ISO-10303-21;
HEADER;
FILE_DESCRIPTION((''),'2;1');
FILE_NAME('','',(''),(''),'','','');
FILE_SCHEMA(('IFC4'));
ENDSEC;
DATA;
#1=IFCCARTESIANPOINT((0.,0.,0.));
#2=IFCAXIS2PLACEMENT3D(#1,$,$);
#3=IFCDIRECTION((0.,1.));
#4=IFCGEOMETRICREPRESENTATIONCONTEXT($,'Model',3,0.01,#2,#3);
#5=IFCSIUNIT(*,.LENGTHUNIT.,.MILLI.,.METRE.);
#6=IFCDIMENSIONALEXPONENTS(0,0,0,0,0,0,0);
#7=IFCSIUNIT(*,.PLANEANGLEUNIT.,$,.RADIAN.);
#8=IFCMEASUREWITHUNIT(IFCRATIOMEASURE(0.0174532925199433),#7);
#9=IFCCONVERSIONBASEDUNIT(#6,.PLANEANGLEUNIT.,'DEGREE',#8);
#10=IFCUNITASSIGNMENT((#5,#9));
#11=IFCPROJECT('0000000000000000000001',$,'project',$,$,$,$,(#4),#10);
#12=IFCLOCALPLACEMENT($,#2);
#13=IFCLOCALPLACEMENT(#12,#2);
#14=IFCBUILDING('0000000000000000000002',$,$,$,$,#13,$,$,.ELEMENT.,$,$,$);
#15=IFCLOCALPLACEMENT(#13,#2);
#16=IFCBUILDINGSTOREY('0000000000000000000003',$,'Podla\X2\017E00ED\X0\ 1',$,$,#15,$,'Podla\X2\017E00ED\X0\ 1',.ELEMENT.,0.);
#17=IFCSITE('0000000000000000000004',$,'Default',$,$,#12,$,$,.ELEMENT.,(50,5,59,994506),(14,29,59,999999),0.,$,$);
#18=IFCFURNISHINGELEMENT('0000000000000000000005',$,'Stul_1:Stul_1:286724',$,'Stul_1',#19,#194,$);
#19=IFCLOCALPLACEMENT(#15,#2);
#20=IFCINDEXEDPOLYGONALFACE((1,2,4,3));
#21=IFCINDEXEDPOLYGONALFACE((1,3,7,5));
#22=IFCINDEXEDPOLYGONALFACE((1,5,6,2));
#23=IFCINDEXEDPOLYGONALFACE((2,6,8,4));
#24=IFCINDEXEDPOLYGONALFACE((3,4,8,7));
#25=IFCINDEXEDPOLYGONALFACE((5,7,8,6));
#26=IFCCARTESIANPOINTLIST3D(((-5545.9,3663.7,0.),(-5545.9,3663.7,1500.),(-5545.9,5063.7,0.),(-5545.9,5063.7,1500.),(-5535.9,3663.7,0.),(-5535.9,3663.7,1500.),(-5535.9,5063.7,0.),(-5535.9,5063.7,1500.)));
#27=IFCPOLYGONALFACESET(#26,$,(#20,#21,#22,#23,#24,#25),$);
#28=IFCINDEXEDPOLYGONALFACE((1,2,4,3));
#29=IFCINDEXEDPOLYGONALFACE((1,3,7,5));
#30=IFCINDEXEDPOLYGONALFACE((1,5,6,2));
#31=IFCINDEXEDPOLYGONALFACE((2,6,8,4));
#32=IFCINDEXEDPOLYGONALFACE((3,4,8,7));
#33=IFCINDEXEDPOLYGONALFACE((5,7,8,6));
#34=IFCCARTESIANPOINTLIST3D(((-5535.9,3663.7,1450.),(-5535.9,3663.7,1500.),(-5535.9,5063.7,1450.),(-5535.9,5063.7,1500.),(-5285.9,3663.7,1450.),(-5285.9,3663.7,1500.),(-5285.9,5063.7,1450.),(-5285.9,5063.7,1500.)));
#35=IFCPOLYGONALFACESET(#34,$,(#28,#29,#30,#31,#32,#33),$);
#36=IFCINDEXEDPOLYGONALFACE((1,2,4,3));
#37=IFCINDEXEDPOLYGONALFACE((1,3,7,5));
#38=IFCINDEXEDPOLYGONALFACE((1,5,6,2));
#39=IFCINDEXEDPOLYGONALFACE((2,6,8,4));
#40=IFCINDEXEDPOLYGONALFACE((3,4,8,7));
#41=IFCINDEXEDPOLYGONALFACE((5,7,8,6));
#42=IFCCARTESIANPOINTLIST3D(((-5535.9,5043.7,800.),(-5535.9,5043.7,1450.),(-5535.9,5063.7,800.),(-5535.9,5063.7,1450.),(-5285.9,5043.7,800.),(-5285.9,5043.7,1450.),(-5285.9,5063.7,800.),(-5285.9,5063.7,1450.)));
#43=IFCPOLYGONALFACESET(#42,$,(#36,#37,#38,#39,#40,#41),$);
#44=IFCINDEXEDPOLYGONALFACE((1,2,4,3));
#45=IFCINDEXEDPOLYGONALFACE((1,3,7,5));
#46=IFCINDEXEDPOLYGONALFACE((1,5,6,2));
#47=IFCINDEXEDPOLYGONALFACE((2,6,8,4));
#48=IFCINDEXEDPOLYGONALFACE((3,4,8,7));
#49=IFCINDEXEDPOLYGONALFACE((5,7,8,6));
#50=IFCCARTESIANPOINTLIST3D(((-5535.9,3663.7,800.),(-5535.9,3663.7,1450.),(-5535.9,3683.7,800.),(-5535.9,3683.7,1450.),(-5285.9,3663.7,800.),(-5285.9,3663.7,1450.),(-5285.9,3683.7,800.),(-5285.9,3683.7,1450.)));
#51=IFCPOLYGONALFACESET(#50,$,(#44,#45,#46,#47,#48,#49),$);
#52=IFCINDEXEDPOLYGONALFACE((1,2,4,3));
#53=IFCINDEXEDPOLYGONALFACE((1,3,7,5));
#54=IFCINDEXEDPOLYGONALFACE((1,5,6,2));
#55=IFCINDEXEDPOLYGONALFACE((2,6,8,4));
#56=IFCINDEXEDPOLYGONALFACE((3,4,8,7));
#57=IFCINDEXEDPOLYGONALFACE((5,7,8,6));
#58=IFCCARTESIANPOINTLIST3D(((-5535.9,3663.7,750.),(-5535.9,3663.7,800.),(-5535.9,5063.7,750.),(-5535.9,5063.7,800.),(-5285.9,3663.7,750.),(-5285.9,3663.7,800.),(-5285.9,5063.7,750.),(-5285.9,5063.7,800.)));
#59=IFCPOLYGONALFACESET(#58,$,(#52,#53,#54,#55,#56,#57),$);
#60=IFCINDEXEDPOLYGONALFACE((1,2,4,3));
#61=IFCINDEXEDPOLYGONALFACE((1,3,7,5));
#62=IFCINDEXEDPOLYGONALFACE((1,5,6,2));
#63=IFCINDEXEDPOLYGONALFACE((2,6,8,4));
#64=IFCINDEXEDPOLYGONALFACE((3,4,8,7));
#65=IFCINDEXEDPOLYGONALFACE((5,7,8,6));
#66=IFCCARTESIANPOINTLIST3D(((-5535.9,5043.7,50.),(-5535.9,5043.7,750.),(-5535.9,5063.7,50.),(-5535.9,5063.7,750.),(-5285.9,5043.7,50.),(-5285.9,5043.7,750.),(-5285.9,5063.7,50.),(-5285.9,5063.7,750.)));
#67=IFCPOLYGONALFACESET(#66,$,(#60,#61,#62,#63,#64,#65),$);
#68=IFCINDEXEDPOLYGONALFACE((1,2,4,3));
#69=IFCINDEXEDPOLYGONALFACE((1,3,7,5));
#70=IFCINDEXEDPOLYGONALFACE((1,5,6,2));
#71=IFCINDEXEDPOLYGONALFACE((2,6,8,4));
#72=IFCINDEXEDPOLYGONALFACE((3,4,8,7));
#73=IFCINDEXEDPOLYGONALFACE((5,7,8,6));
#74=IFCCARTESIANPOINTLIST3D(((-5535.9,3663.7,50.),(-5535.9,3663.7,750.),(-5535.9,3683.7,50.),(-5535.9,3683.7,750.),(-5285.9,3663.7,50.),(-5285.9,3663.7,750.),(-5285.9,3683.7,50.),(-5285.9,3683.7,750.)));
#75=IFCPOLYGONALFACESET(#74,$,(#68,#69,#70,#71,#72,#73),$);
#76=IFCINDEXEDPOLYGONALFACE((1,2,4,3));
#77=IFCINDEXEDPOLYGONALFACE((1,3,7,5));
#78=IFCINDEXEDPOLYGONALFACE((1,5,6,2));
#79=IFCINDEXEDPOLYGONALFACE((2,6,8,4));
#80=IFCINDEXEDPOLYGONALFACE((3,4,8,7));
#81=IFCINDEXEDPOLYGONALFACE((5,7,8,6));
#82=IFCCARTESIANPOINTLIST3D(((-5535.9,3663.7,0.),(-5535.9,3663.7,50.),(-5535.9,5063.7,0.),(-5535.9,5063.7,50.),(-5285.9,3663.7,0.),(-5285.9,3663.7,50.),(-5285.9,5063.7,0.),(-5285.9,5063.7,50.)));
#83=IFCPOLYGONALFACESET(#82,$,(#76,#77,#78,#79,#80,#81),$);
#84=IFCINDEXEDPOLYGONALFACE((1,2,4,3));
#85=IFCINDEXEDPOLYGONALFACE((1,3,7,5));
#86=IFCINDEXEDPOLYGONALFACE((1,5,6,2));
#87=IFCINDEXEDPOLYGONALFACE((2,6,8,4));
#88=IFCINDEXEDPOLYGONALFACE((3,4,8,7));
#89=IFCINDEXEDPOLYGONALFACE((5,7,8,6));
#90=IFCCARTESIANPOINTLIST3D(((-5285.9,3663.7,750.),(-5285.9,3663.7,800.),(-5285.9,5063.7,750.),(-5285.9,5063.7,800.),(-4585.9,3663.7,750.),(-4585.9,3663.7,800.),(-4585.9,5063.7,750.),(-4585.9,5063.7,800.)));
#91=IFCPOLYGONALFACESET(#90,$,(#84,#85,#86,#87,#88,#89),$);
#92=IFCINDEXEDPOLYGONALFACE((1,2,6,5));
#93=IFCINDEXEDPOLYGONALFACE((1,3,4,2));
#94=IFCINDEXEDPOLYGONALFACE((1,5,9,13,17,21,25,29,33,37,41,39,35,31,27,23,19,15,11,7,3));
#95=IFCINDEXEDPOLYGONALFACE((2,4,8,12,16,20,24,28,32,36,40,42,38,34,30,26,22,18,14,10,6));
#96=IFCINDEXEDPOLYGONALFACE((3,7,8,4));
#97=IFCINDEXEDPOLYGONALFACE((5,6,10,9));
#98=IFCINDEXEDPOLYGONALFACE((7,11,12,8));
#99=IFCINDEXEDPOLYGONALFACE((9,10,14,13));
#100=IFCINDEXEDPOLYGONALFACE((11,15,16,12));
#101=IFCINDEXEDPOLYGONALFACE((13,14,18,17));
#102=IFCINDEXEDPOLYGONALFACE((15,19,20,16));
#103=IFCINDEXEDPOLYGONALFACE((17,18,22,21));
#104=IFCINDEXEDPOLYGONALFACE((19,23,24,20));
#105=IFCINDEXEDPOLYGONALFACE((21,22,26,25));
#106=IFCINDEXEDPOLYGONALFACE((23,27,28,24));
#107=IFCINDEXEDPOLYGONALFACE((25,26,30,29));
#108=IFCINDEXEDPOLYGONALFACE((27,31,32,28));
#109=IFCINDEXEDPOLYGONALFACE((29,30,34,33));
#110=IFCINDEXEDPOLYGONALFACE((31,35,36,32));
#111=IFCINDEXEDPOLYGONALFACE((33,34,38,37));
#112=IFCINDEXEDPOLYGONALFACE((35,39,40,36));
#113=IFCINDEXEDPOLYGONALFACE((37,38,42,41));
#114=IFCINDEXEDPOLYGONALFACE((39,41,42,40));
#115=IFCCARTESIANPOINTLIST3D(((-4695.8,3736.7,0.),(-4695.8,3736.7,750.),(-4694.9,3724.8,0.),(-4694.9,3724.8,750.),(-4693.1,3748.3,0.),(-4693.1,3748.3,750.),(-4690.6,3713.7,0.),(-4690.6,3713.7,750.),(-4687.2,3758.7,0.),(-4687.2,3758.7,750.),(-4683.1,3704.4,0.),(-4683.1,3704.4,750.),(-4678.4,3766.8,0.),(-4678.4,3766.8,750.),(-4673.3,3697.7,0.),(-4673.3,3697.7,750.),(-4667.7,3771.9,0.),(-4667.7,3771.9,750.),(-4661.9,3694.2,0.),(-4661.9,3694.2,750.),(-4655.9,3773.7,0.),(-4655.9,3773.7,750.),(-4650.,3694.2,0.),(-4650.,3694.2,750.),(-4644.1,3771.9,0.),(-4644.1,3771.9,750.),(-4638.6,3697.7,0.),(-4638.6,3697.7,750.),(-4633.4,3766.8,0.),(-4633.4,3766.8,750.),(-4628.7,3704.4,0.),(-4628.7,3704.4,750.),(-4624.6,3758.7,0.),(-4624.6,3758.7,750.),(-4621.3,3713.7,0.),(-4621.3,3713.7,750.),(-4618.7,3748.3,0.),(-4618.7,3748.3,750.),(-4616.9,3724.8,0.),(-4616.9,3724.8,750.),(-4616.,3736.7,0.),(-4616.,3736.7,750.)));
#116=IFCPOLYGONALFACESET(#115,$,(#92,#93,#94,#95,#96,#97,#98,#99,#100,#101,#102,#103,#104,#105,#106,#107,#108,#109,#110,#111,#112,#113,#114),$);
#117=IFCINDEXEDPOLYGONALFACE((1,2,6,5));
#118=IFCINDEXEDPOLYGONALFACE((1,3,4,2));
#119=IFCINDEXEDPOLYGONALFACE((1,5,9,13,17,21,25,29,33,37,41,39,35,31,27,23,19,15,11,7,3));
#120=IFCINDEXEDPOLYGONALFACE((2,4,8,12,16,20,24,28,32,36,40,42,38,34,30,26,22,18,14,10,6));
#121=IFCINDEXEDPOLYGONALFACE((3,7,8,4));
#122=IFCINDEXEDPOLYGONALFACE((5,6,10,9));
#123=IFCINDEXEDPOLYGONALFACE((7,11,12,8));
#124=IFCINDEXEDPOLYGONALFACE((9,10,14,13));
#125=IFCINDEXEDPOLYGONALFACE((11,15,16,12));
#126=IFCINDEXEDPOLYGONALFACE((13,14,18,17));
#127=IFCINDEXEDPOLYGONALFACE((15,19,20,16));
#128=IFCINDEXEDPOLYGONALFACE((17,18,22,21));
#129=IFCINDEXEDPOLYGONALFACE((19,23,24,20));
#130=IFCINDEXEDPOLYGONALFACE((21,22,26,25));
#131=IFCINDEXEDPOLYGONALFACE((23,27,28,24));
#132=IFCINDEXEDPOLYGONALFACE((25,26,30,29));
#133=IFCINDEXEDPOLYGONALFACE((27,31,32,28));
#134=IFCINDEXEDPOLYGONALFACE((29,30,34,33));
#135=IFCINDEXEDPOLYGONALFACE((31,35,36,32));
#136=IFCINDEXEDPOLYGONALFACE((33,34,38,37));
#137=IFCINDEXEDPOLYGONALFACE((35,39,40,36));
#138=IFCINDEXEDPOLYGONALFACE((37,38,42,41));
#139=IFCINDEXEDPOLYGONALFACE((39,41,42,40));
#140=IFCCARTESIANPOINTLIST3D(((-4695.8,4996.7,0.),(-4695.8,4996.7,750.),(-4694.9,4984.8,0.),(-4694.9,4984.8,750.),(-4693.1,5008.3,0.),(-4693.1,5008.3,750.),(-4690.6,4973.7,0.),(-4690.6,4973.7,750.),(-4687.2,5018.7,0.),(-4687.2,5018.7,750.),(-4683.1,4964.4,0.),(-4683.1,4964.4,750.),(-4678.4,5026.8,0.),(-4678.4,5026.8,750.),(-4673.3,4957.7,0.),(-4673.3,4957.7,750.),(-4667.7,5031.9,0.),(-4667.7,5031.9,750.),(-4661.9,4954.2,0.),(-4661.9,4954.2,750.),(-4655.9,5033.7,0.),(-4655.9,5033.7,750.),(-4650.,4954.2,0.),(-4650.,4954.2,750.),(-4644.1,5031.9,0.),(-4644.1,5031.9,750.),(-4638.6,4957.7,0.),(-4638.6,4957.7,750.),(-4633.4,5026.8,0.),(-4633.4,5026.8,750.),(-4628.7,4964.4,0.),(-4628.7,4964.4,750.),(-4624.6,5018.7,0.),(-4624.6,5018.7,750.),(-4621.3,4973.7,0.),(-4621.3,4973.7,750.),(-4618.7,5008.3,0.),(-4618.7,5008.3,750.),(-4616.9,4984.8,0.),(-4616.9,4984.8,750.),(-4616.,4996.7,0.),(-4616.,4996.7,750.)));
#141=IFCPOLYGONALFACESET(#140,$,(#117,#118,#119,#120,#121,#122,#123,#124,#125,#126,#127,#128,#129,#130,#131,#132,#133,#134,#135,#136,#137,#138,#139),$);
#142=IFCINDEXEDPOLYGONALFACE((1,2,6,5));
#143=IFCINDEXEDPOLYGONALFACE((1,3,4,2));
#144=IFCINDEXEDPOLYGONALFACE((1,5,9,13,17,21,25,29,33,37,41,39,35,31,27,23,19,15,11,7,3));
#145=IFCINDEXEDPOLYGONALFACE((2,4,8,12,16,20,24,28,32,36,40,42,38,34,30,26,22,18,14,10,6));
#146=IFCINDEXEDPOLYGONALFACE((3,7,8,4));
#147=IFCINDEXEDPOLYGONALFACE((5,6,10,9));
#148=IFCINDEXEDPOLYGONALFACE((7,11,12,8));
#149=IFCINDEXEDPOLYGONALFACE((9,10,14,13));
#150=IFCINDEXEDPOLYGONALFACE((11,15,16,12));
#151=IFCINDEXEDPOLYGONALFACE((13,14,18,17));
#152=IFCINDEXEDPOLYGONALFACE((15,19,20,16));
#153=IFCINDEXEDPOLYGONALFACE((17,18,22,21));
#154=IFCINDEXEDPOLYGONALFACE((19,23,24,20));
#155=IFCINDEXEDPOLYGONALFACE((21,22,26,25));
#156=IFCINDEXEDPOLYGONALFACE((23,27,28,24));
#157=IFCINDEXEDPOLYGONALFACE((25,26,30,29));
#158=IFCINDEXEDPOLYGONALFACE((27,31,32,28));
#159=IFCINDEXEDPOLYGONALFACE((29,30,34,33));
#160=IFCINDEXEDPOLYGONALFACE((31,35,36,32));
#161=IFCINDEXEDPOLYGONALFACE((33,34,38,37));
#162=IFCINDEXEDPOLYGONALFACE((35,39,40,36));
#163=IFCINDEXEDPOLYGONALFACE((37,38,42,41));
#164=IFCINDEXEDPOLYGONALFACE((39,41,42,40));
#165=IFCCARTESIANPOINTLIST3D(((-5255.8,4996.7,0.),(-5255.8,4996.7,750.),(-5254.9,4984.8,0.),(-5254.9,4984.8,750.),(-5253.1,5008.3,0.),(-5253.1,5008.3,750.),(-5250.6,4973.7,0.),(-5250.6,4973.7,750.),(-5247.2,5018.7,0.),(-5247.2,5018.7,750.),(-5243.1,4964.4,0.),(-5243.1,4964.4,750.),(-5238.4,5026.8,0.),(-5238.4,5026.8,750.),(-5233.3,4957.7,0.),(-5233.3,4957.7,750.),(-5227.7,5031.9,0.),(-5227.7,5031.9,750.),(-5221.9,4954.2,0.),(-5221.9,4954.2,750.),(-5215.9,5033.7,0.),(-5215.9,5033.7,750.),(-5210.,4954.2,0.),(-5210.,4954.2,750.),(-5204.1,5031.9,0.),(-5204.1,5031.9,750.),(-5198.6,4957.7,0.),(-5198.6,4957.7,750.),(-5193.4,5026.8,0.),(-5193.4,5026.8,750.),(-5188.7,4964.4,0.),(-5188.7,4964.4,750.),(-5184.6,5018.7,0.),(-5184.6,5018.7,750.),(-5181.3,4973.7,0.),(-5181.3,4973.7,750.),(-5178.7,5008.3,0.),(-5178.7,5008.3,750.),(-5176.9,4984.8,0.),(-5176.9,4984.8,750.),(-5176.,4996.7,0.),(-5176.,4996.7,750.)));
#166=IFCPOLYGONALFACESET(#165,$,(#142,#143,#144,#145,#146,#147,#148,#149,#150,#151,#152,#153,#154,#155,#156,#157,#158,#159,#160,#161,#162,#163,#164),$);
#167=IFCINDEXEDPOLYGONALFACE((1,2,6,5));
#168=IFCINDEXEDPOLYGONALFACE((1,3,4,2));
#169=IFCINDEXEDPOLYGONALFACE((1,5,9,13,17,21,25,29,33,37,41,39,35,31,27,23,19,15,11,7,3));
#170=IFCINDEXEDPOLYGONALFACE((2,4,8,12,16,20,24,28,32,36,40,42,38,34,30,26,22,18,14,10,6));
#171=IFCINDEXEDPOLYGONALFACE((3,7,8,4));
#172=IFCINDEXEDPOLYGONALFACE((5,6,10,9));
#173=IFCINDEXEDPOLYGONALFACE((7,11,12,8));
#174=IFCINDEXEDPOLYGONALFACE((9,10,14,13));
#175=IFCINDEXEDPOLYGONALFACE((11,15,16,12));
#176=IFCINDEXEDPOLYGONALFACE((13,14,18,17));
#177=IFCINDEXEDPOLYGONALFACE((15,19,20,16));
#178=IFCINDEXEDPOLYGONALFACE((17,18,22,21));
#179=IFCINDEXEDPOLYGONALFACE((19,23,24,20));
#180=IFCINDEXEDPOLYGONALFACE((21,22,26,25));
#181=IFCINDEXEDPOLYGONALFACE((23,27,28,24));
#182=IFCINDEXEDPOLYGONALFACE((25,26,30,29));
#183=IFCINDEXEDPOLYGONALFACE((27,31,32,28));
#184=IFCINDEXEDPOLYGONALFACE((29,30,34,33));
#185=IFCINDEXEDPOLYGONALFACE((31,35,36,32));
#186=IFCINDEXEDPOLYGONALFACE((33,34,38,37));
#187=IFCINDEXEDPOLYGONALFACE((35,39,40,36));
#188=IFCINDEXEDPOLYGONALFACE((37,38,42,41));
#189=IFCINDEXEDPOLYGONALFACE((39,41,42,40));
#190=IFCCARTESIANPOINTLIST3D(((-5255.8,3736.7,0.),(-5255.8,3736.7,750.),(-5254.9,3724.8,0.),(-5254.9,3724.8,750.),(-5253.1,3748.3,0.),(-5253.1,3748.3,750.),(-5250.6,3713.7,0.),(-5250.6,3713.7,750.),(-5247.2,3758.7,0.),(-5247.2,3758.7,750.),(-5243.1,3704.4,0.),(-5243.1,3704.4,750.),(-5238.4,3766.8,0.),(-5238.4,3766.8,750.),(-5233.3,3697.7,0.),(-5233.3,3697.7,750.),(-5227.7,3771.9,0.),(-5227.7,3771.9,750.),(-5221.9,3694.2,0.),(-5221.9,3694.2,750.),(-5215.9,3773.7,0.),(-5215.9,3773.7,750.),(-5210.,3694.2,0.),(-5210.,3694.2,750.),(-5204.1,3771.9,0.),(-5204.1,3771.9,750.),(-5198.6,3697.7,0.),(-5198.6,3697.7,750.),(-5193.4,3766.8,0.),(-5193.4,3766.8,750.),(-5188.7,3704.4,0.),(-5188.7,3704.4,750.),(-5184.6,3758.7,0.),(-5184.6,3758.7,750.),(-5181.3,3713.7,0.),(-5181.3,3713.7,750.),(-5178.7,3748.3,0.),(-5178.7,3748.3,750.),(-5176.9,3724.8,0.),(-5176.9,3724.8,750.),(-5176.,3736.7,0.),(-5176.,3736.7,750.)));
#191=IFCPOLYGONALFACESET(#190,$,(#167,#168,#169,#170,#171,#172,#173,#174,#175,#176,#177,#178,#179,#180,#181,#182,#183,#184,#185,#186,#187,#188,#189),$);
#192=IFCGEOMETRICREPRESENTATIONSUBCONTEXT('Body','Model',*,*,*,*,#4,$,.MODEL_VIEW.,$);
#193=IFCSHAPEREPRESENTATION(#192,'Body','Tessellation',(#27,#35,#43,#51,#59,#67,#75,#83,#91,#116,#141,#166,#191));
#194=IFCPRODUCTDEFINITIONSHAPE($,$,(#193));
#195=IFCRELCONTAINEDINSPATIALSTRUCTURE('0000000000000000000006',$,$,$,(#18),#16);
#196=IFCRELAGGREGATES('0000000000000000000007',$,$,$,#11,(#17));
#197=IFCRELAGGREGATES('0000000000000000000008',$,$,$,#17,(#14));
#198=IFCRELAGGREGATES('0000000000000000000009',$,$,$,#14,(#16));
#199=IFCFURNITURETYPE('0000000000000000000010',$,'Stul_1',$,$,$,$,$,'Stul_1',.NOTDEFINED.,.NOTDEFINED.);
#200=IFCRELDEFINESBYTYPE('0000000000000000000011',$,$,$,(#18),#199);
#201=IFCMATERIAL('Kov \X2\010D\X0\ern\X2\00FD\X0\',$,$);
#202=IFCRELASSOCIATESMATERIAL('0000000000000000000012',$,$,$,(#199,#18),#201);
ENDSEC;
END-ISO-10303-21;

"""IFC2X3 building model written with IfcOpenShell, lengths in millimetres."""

from ifc_helpers import new_model, entity, si_unit, converted_unit, direction, frame, frame_2d, origin, origin_2d_with_axis, place, context, subcontext, project, spatial, rectangle, circle, extrude, source, transform, mapped, material, type_object, type_shapes, element, save


model = new_model("IFC2X3")

# Units and contexts
model_context = context("Model", 3, precision=0.01, world=origin(), true_north=direction((0.0, 1.0)))
body_context = subcontext(model_context, "Body", "Model", "MODEL_VIEW")
ifc_project = project(units=[si_unit("LENGTHUNIT", "METRE", prefix="MILLI"), converted_unit("PLANEANGLEUNIT", "DEGREE", entity("IfcRatioMeasure", 0.0174532925199433), si_unit("PLANEANGLEUNIT", "RADIAN"), dimensions=[0, 0, 0, 0, 0, 0, 0])], contexts=[model_context])

# Site, building, storey
site_placement = place(None, origin())
site = spatial("IfcSite", under=ifc_project, at=site_placement, Name="Default", CompositionType="ELEMENT", RefLatitude=(50, 5, 59, 994506), RefLongitude=(14, 29, 59, 999999), RefElevation=0.0)
building_placement = place(site_placement, origin())
building = spatial("IfcBuilding", under=site, at=building_placement, CompositionType="ELEMENT")
storey_placement = place(building_placement, origin())
storey = spatial("IfcBuildingStorey", under=building, at=storey_placement, Name="Podlaží 1", LongName="Podlaží 1", CompositionType="ELEMENT", Elevation=0.0)

# Furnishing element
ifc_material_1 = material(Name="Kov černý")
furniture_type = type_object("IfcFurnitureType", Name="Stul_1", ElementType="Stul_1", material=ifc_material_1)
shared_shape_1 = source(origin(), body_context, "Body", "SweptSolid", [
    extrude(rectangle(XDim=1400.0, YDim=10.0, at=origin_2d_with_axis()), frame((0.0, 605.0, 0.0), z_axis=(0.0, 0.0, 1.0), x_axis=(-1.0, 0.0, 0.0)), (0.0, 0.0, 1.0), 1500.0),
    extrude(rectangle(XDim=1400.0, YDim=250.0, at=frame_2d((0.0, 0.0), x_axis=(1.0, 0.0))), frame((0.0, 475.0, 1450.0), z_axis=(0.0, 0.0, 1.0), x_axis=(-1.0, 0.0, 0.0)), (0.0, 0.0, 1.0), 50.0),
    extrude(rectangle(XDim=20.0, YDim=250.0, at=origin_2d_with_axis()), frame((690.0, 475.0, 800.0), z_axis=(0.0, 0.0, 1.0), x_axis=(-1.0, 0.0, 0.0)), (0.0, 0.0, 1.0), 650.0),
    extrude(rectangle(XDim=20.0, YDim=250.0, at=frame_2d((0.0, 0.0), x_axis=(1.0, 0.0))), frame((-690.0, 475.0, 800.0), z_axis=(0.0, 0.0, 1.0), x_axis=(-1.0, 0.0, 0.0)), (0.0, 0.0, 1.0), 650.0),
    extrude(rectangle(XDim=1400.0, YDim=250.0, at=origin_2d_with_axis()), frame((0.0, 475.0, 750.0), z_axis=(0.0, 0.0, 1.0), x_axis=(-1.0, 0.0, 0.0)), (0.0, 0.0, 1.0), 50.0),
    extrude(rectangle(XDim=20.0, YDim=250.0, at=origin_2d_with_axis()), frame((690.0, 475.0, 50.0), z_axis=(0.0, 0.0, 1.0), x_axis=(-1.0, 0.0, 0.0)), (0.0, 0.0, 1.0), 700.0),
    extrude(rectangle(XDim=20.0, YDim=250.0, at=frame_2d((0.0, 0.0), x_axis=(1.0, 0.0))), frame((-690.0, 475.0, 50.0), z_axis=(0.0, 0.0, 1.0), x_axis=(-1.0, 0.0, 0.0)), (0.0, 0.0, 1.0), 700.0),
    extrude(rectangle(XDim=1400.0, YDim=250.0, at=origin_2d_with_axis()), frame((0.0, 475.0, 0.0), z_axis=(0.0, 0.0, 1.0), x_axis=(-1.0, 0.0, 0.0)), (0.0, 0.0, 1.0), 50.0),
    extrude(rectangle(XDim=1400.0, YDim=700.0, at=origin_2d_with_axis()), frame((0.0, 0.0, 750.0), z_axis=(0.0, 0.0, 1.0), x_axis=(-1.0, 0.0, 0.0)), (0.0, 0.0, 1.0), 50.0),
    extrude(circle(Radius=40.0, at=frame_2d((0.0, 0.0), x_axis=(1.0, 0.0))), frame((-630.0, -280.0, 0.0)), (0.0, 0.0, 1.0), 750.0),
    extrude(circle(Radius=40.0, at=frame_2d((0.0, 0.0), x_axis=(1.0, 0.0))), frame((630.0, -280.0, 0.0)), (0.0, 0.0, 1.0), 750.0),
    extrude(circle(Radius=40.0, at=frame_2d((0.0, 0.0), x_axis=(1.0, 0.0))), frame((630.0, 280.0, 0.0)), (0.0, 0.0, 1.0), 750.0),
    extrude(circle(Radius=40.0, at=frame_2d((0.0, 0.0), x_axis=(1.0, 0.0))), frame((-630.0, 280.0, 0.0)), (0.0, 0.0, 1.0), 750.0),
])
type_shapes(furniture_type, [shared_shape_1])
for number, where, z_axis, x_axis, name in (
    (1, (-4935.9, 4363.7, 0.0), (0.0, 0.0, 1.0), (0.0, 1.0, 0.0), "Stul_1:Stul_1:286724"),
):
    element("IfcFurnishingElement", number, at=place(storey_placement, frame(where, z_axis=z_axis, x_axis=x_axis)), inside=storey, type_object=furniture_type, material=ifc_material_1, Name=name, ObjectType="Stul_1", context=body_context, shape_type="MappedRepresentation", body=[
        mapped(shared_shape_1, transform((0.0, 0.0, 0.0), scale=1.0)),
    ])

save(model, "model.ifc")
